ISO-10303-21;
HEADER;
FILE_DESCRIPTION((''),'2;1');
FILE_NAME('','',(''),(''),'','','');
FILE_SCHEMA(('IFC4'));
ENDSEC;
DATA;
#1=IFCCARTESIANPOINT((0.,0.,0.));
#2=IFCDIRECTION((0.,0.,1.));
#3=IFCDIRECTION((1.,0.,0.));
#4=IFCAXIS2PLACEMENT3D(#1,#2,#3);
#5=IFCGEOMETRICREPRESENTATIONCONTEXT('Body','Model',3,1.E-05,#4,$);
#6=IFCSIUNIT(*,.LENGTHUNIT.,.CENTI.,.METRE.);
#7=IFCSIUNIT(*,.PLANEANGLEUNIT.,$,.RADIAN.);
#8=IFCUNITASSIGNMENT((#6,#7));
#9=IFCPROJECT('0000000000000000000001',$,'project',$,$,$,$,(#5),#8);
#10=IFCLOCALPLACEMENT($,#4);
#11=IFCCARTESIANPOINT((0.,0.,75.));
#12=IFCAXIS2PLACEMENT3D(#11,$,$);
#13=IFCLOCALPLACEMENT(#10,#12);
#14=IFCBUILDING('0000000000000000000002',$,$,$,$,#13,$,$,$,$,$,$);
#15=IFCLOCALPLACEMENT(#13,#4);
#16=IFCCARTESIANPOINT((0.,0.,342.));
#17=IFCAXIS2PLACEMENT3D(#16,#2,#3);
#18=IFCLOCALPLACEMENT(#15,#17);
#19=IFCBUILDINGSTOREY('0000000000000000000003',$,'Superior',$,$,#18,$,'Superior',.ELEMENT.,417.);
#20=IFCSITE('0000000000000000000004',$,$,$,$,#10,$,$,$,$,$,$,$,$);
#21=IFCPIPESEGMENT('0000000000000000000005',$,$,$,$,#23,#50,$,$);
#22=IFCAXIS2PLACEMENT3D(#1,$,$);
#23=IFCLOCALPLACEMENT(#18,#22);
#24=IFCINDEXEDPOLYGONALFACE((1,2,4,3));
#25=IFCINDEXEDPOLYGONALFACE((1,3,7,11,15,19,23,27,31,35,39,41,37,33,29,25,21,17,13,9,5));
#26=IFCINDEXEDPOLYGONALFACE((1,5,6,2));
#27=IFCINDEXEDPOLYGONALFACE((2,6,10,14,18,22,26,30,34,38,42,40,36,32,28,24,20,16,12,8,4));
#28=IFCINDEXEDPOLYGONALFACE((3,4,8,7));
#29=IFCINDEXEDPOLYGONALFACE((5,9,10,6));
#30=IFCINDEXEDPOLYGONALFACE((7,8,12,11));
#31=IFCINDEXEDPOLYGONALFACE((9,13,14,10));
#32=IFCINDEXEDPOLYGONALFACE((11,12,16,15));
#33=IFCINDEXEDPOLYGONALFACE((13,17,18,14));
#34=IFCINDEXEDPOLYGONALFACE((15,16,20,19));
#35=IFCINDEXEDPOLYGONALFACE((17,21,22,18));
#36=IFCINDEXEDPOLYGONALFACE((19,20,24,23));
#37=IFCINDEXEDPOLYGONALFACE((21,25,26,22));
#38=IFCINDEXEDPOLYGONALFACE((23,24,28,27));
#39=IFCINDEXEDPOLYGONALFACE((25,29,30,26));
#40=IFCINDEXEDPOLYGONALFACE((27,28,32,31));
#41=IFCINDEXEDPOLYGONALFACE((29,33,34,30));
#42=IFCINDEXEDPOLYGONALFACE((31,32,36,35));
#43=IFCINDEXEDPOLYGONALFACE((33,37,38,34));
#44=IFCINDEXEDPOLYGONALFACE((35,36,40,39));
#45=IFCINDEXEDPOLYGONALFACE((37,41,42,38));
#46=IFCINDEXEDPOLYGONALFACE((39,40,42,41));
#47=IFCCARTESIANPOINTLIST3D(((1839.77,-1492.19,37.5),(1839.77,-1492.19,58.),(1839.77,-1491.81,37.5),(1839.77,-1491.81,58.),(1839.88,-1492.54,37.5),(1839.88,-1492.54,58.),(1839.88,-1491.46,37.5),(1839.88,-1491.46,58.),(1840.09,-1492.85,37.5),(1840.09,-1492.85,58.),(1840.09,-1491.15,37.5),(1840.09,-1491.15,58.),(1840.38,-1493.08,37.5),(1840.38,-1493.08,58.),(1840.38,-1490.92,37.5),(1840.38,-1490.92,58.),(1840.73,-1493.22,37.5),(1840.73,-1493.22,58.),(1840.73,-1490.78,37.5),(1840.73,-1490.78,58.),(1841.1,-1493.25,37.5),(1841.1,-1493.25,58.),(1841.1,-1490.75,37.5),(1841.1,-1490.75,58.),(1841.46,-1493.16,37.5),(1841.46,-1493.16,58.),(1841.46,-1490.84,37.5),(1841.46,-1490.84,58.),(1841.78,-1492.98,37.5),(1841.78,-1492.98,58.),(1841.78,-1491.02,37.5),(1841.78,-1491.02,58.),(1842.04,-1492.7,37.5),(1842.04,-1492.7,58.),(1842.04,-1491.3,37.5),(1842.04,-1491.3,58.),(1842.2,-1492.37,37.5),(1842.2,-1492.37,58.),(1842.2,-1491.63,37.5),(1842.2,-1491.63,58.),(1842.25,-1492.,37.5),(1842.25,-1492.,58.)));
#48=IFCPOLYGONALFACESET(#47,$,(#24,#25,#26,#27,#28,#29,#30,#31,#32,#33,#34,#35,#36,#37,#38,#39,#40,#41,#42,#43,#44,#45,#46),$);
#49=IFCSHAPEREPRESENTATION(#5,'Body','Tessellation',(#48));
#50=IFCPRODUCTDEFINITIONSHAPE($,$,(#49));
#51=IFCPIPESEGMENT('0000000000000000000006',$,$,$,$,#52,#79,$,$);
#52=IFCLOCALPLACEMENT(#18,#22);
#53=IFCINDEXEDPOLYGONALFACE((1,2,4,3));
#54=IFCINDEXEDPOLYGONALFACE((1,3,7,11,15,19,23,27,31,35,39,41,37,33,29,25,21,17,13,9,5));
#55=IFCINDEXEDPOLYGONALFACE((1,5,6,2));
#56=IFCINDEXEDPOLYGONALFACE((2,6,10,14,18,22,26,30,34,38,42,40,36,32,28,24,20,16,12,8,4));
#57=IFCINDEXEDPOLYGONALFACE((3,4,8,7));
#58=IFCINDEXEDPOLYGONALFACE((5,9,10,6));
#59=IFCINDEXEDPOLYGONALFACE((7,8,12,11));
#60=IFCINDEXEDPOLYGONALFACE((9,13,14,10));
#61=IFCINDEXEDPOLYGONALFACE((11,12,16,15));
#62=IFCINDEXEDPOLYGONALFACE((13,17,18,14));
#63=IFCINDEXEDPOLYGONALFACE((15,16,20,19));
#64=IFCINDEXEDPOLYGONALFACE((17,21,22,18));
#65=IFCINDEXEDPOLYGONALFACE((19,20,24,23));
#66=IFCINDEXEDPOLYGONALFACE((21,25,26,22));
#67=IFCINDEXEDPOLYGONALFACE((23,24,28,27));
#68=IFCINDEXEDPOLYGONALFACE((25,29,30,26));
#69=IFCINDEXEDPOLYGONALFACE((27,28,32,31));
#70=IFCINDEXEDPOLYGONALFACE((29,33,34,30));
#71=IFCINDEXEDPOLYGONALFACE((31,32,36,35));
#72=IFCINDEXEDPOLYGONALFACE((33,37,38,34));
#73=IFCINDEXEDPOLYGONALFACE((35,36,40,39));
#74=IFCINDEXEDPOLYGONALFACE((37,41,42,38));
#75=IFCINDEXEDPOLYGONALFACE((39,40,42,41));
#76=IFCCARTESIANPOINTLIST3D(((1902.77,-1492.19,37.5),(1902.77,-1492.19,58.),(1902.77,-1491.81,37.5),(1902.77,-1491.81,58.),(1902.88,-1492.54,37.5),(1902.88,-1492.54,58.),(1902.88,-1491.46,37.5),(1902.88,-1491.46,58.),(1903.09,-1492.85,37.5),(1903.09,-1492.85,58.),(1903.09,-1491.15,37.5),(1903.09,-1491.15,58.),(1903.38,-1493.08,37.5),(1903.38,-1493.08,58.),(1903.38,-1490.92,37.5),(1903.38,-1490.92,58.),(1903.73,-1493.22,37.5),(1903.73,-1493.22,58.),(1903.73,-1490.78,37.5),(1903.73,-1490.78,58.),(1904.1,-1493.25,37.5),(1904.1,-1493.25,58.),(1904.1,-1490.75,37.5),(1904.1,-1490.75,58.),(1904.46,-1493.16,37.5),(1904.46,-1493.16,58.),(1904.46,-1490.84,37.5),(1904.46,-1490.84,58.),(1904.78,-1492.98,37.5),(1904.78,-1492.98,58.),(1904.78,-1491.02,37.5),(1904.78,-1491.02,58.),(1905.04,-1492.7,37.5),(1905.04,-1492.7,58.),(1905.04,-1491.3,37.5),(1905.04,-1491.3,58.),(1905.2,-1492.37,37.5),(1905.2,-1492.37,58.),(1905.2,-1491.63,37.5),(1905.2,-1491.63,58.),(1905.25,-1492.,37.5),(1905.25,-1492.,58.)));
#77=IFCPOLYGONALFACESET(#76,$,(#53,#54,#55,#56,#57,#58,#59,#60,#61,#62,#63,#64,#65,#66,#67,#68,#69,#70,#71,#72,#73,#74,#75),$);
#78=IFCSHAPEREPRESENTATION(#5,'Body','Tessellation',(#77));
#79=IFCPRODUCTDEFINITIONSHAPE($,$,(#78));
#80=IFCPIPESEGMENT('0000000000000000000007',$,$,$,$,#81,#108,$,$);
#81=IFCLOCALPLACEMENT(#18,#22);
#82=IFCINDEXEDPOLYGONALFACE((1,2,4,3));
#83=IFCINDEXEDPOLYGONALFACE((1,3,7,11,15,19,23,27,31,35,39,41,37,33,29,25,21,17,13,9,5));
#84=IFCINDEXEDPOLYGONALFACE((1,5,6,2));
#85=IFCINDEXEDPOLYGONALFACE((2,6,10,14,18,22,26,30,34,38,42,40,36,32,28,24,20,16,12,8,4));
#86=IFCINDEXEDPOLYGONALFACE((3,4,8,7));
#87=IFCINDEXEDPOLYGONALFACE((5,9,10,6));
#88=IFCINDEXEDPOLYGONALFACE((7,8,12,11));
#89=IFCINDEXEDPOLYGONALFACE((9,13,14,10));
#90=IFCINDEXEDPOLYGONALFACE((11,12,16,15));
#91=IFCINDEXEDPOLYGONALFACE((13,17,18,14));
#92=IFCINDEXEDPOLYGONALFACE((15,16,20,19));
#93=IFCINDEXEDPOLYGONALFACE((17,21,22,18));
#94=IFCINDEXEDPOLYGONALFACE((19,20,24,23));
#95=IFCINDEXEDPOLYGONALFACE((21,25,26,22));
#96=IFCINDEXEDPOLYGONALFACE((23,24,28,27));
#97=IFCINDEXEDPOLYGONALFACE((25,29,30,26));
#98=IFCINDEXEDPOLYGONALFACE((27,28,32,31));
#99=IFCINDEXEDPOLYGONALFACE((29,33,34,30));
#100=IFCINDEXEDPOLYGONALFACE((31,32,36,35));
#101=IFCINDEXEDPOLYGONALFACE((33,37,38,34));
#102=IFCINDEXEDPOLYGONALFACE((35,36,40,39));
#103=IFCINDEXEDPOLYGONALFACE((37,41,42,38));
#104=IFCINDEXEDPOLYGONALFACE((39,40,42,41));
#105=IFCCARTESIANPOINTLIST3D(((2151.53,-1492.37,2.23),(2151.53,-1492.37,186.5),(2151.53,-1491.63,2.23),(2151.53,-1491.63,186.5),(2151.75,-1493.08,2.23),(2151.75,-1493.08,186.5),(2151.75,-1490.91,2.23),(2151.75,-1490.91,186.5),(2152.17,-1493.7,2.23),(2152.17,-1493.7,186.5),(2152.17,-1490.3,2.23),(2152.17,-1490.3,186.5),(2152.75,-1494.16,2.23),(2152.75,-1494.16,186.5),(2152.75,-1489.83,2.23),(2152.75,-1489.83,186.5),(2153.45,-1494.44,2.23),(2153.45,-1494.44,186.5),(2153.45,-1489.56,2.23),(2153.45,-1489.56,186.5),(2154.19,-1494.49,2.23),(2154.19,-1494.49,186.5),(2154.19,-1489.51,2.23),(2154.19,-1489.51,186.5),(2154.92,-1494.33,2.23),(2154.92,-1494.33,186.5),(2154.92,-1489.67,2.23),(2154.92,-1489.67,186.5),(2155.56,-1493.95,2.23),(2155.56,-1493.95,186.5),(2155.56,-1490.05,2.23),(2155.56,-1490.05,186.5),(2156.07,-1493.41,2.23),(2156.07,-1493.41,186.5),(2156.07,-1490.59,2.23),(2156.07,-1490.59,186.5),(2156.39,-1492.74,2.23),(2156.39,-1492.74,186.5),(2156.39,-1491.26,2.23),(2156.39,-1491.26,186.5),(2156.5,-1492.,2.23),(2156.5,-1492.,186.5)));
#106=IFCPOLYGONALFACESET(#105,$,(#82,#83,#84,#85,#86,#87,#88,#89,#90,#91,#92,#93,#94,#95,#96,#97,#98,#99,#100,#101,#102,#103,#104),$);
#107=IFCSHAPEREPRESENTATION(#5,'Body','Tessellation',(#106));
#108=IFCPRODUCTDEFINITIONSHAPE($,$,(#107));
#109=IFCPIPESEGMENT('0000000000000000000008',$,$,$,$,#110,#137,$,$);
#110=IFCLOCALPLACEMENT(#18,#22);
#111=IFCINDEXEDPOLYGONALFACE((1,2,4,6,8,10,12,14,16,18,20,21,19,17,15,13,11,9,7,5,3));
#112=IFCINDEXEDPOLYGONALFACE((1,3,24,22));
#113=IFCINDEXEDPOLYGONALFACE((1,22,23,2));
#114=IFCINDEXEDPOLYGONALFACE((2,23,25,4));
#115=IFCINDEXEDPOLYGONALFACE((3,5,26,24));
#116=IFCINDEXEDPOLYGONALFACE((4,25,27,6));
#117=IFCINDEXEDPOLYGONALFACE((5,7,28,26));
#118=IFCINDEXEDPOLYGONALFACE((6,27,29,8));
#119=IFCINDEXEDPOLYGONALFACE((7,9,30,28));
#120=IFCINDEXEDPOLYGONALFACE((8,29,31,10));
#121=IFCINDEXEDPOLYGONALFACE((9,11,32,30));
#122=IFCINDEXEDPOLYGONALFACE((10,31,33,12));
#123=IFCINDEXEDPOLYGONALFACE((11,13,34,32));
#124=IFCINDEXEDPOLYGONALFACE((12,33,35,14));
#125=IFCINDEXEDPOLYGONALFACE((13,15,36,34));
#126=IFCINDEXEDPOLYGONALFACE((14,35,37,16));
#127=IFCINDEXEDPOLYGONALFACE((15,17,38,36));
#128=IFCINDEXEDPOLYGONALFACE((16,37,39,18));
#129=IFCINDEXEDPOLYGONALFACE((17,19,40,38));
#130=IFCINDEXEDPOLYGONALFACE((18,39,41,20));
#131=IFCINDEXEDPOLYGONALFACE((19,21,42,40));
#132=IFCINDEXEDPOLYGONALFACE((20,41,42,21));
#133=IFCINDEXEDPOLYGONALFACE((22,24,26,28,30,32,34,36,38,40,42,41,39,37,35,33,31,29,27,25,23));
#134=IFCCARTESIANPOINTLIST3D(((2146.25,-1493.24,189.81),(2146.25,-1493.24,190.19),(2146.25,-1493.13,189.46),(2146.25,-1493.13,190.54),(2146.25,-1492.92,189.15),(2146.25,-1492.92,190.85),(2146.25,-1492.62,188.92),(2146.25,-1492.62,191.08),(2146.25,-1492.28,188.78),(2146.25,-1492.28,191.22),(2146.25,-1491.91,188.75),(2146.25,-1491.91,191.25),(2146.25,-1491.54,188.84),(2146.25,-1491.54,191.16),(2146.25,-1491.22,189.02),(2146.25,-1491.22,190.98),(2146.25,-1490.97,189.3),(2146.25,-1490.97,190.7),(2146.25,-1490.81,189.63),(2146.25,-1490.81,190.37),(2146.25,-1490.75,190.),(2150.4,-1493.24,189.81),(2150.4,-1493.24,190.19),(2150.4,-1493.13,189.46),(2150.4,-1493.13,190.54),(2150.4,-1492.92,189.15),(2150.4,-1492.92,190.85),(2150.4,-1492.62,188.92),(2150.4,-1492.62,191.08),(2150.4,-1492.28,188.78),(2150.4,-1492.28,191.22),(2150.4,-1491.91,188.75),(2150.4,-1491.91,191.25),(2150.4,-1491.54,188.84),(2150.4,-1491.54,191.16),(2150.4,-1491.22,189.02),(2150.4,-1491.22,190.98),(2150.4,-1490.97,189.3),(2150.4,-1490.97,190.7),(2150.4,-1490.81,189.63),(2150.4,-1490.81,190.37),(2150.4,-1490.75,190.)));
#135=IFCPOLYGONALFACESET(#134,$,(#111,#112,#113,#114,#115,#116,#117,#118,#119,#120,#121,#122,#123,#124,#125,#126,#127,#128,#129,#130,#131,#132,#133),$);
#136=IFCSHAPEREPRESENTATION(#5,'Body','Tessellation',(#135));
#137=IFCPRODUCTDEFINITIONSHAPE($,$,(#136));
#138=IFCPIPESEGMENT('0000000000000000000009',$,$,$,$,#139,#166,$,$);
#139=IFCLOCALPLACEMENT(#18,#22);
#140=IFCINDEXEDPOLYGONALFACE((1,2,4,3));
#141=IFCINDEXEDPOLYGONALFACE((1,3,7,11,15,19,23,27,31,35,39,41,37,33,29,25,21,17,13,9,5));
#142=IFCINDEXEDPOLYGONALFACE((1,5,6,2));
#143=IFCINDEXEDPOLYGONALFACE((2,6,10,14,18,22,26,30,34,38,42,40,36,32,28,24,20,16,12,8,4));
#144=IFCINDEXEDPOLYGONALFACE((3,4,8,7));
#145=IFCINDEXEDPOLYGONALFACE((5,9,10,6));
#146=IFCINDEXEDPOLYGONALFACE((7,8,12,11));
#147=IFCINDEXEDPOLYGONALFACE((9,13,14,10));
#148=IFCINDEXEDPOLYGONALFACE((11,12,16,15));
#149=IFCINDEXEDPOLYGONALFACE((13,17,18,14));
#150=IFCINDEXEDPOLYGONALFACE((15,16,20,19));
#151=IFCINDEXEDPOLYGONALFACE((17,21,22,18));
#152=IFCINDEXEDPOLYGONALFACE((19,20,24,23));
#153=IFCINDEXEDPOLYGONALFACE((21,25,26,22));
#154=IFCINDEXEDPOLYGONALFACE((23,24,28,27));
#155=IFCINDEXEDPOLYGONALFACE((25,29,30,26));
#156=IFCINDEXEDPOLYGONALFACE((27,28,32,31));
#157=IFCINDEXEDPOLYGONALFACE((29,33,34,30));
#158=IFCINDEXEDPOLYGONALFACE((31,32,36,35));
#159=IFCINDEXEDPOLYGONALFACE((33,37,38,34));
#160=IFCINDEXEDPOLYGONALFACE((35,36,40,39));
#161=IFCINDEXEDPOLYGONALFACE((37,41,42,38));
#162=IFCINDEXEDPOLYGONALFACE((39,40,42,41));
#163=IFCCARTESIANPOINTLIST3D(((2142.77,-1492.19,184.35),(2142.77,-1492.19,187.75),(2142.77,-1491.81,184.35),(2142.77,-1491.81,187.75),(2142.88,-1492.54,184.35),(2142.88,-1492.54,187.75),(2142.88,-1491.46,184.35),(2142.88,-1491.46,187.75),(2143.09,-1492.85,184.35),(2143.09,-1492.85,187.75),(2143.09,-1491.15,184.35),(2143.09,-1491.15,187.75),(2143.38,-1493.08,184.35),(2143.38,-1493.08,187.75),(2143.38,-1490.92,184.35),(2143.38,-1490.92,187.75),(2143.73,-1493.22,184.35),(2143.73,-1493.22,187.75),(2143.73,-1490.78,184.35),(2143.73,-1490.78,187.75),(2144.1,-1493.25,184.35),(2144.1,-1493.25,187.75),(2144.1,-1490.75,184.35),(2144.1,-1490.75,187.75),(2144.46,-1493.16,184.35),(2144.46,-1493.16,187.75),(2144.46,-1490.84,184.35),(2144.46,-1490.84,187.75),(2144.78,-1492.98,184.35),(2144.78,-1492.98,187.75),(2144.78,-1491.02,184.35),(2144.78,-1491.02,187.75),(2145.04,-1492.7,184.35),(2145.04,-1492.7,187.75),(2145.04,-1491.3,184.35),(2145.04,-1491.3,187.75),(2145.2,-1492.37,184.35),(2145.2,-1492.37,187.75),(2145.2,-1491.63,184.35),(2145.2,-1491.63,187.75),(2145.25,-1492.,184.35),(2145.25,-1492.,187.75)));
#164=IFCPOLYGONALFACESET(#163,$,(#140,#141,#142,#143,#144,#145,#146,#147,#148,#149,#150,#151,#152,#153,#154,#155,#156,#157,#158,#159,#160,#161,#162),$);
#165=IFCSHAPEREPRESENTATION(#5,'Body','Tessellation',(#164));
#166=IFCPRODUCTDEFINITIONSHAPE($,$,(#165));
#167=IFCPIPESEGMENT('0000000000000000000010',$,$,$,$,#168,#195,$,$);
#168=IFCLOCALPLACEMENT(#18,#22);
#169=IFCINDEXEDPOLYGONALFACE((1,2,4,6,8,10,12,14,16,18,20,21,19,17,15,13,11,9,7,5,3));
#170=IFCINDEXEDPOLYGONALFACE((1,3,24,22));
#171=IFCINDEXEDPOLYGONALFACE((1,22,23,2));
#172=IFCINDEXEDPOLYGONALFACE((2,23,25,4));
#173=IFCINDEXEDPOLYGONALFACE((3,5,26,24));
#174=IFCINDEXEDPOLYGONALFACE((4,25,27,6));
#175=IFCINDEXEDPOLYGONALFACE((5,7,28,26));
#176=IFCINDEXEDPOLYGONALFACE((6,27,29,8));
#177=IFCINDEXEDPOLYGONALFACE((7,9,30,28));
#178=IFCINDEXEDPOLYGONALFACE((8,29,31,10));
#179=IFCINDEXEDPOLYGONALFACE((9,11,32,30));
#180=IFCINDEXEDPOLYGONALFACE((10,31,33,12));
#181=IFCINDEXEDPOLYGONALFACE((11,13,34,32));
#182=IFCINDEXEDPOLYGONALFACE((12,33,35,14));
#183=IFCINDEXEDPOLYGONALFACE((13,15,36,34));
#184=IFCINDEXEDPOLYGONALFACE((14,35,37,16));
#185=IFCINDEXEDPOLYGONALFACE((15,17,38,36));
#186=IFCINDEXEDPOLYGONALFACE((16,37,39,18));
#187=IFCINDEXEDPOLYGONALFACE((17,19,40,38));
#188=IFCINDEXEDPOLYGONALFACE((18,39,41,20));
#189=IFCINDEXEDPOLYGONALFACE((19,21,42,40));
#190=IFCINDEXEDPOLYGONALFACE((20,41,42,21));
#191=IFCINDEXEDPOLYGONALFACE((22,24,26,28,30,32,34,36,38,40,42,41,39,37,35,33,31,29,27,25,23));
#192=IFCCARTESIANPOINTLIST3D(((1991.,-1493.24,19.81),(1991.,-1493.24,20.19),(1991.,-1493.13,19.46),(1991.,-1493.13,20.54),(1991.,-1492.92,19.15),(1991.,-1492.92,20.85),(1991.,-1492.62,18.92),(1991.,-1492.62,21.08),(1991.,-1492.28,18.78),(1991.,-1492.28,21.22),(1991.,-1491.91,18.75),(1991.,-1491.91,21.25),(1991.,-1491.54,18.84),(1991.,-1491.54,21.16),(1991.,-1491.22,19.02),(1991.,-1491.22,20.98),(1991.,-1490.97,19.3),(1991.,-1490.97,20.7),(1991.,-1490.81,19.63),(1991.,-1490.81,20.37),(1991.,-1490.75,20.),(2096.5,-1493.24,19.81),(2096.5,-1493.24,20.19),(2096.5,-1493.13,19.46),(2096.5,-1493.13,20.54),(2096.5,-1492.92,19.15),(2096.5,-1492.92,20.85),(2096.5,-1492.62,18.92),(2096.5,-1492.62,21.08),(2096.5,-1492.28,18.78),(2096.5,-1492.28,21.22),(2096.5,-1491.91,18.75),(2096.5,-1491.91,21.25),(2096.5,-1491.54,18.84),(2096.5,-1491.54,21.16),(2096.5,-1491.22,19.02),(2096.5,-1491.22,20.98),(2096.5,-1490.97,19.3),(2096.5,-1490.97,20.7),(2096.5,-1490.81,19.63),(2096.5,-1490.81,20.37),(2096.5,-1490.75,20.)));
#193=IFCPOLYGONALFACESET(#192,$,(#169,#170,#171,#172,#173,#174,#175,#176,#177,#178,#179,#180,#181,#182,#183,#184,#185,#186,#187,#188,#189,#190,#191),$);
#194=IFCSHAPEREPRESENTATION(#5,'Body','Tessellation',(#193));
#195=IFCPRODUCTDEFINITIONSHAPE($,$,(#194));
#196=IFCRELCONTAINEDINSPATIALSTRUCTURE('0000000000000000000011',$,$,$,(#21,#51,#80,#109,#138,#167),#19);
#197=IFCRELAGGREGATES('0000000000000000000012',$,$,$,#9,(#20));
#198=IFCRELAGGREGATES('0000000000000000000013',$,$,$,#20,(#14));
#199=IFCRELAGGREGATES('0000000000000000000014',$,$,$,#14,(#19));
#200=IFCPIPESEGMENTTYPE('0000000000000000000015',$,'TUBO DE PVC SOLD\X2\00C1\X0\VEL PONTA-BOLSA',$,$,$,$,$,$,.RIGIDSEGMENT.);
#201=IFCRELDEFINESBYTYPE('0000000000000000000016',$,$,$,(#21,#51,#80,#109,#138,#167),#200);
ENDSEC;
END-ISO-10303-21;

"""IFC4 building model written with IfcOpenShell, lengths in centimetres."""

from ifc_helpers import new_model, si_unit, frame, origin_with_axes, origin_2d_with_axis, place, context, project, spatial, circle, extrude, type_object, element, save


model = new_model("IFC4")

# Units and contexts
model_context = context("Model", 3, precision=1e-05, world=origin_with_axes(), identifier="Body")
ifc_project = project(units=[si_unit("LENGTHUNIT", "METRE", prefix="CENTI"), si_unit("PLANEANGLEUNIT", "RADIAN")], contexts=[model_context])

# Site, building, storey
site_placement = place(None, origin_with_axes())
site = spatial("IfcSite", under=ifc_project, at=site_placement)
building_placement = place(site_placement, frame((0.0, 0.0, 75.0)))
building = spatial("IfcBuilding", under=site, at=building_placement)
placement = place(building_placement, origin_with_axes())
storey_placement = place(placement, frame((0.0, 0.0, 342.0), z_axis=(0.0, 0.0, 1.0), x_axis=(1.0, 0.0, 0.0)))
storey = spatial("IfcBuildingStorey", under=building, at=storey_placement, Name="Superior", LongName="Superior", CompositionType="ELEMENT", Elevation=417.0)

# Pipe segments
pipe_segment_type_1 = type_object("IfcPipeSegmentType", Name="TUBO DE PVC SOLDÁVEL PONTA-BOLSA", PredefinedType="RIGIDSEGMENT")
for number, where, z_axis, x_axis in (
    (1, (1841.0, -1492.0, 58.0), (0.0, 0.0, 1.0), (1.0, 0.0, 0.0)),
    (2, (1904.0, -1492.0, 58.0), (0.0, 0.0, 1.0), (1.0, 0.0, 0.0)),
):
    element("IfcPipeSegment", number, at=place(storey_placement, frame(where, z_axis=z_axis, x_axis=x_axis)), inside=storey, type_object=pipe_segment_type_1, context=model_context, shape_type="SolidModel", body=[
        extrude(circle(Radius=1.25, at=origin_2d_with_axis()), frame((0.0, 0.0, -20.5), z_axis=(0.0, 0.0, 1.0), x_axis=(1.0, 0.0, 0.0)), (0.0, 0.0, 1.0), 20.5),
    ])
pipe_segment_1_placement = place(storey_placement, frame((2154.0, -1492.0, 186.5), z_axis=(0.0, 0.0, 1.0), x_axis=(1.0, 0.0, 0.0)))
element("IfcPipeSegment", 3, at=pipe_segment_1_placement, inside=storey, type_object=pipe_segment_type_1, context=model_context, shape_type="SolidModel", body=[
    extrude(circle(Radius=2.5, at=origin_2d_with_axis()), frame((0.0, 0.0, 0.0), z_axis=(0.0, 0.0, -1.0), x_axis=(1.0, 0.0, 0.0)), (0.0, 0.0, 1.0), 184.27),
])
pipe_segment_2_placement = place(storey_placement, frame((2148.33, -1492.0, 191.25), z_axis=(0.0, 0.0, 1.0), x_axis=(1.0, 0.0, 0.0)))
element("IfcPipeSegment", 4, at=pipe_segment_2_placement, inside=storey, type_object=pipe_segment_type_1, context=model_context, shape_type="SolidModel", body=[
    extrude(circle(Radius=1.25, at=origin_2d_with_axis()), frame((2.07, 0.0, -1.25), z_axis=(-1.0, 0.0, 0.0), x_axis=(0.0, 1.0, 0.0)), (0.0, 0.0, 1.0), 4.15),
])
pipe_segment_3_placement = place(storey_placement, frame((2144.0, -1492.0, 187.75), z_axis=(0.0, 0.0, 1.0), x_axis=(1.0, 0.0, 0.0)))
element("IfcPipeSegment", 5, at=pipe_segment_3_placement, inside=storey, type_object=pipe_segment_type_1, context=model_context, shape_type="SolidModel", body=[
    extrude(circle(Radius=1.25, at=origin_2d_with_axis()), frame((0.0, 0.0, 0.0), z_axis=(0.0, 0.0, -1.0), x_axis=(1.0, 0.0, 0.0)), (0.0, 0.0, 1.0), 3.4),
])
pipe_segment_4_placement = place(storey_placement, frame((2043.75, -1492.0, 21.25), z_axis=(0.0, 0.0, 1.0), x_axis=(1.0, 0.0, 0.0)))
element("IfcPipeSegment", 6, at=pipe_segment_4_placement, inside=storey, type_object=pipe_segment_type_1, context=model_context, shape_type="SolidModel", body=[
    extrude(circle(Radius=1.25, at=origin_2d_with_axis()), frame((52.75, 0.0, -1.25), z_axis=(-1.0, 0.0, 0.0), x_axis=(0.0, 1.0, 0.0)), (0.0, 0.0, 1.0), 105.5),
])

save(model, "model.ifc")
